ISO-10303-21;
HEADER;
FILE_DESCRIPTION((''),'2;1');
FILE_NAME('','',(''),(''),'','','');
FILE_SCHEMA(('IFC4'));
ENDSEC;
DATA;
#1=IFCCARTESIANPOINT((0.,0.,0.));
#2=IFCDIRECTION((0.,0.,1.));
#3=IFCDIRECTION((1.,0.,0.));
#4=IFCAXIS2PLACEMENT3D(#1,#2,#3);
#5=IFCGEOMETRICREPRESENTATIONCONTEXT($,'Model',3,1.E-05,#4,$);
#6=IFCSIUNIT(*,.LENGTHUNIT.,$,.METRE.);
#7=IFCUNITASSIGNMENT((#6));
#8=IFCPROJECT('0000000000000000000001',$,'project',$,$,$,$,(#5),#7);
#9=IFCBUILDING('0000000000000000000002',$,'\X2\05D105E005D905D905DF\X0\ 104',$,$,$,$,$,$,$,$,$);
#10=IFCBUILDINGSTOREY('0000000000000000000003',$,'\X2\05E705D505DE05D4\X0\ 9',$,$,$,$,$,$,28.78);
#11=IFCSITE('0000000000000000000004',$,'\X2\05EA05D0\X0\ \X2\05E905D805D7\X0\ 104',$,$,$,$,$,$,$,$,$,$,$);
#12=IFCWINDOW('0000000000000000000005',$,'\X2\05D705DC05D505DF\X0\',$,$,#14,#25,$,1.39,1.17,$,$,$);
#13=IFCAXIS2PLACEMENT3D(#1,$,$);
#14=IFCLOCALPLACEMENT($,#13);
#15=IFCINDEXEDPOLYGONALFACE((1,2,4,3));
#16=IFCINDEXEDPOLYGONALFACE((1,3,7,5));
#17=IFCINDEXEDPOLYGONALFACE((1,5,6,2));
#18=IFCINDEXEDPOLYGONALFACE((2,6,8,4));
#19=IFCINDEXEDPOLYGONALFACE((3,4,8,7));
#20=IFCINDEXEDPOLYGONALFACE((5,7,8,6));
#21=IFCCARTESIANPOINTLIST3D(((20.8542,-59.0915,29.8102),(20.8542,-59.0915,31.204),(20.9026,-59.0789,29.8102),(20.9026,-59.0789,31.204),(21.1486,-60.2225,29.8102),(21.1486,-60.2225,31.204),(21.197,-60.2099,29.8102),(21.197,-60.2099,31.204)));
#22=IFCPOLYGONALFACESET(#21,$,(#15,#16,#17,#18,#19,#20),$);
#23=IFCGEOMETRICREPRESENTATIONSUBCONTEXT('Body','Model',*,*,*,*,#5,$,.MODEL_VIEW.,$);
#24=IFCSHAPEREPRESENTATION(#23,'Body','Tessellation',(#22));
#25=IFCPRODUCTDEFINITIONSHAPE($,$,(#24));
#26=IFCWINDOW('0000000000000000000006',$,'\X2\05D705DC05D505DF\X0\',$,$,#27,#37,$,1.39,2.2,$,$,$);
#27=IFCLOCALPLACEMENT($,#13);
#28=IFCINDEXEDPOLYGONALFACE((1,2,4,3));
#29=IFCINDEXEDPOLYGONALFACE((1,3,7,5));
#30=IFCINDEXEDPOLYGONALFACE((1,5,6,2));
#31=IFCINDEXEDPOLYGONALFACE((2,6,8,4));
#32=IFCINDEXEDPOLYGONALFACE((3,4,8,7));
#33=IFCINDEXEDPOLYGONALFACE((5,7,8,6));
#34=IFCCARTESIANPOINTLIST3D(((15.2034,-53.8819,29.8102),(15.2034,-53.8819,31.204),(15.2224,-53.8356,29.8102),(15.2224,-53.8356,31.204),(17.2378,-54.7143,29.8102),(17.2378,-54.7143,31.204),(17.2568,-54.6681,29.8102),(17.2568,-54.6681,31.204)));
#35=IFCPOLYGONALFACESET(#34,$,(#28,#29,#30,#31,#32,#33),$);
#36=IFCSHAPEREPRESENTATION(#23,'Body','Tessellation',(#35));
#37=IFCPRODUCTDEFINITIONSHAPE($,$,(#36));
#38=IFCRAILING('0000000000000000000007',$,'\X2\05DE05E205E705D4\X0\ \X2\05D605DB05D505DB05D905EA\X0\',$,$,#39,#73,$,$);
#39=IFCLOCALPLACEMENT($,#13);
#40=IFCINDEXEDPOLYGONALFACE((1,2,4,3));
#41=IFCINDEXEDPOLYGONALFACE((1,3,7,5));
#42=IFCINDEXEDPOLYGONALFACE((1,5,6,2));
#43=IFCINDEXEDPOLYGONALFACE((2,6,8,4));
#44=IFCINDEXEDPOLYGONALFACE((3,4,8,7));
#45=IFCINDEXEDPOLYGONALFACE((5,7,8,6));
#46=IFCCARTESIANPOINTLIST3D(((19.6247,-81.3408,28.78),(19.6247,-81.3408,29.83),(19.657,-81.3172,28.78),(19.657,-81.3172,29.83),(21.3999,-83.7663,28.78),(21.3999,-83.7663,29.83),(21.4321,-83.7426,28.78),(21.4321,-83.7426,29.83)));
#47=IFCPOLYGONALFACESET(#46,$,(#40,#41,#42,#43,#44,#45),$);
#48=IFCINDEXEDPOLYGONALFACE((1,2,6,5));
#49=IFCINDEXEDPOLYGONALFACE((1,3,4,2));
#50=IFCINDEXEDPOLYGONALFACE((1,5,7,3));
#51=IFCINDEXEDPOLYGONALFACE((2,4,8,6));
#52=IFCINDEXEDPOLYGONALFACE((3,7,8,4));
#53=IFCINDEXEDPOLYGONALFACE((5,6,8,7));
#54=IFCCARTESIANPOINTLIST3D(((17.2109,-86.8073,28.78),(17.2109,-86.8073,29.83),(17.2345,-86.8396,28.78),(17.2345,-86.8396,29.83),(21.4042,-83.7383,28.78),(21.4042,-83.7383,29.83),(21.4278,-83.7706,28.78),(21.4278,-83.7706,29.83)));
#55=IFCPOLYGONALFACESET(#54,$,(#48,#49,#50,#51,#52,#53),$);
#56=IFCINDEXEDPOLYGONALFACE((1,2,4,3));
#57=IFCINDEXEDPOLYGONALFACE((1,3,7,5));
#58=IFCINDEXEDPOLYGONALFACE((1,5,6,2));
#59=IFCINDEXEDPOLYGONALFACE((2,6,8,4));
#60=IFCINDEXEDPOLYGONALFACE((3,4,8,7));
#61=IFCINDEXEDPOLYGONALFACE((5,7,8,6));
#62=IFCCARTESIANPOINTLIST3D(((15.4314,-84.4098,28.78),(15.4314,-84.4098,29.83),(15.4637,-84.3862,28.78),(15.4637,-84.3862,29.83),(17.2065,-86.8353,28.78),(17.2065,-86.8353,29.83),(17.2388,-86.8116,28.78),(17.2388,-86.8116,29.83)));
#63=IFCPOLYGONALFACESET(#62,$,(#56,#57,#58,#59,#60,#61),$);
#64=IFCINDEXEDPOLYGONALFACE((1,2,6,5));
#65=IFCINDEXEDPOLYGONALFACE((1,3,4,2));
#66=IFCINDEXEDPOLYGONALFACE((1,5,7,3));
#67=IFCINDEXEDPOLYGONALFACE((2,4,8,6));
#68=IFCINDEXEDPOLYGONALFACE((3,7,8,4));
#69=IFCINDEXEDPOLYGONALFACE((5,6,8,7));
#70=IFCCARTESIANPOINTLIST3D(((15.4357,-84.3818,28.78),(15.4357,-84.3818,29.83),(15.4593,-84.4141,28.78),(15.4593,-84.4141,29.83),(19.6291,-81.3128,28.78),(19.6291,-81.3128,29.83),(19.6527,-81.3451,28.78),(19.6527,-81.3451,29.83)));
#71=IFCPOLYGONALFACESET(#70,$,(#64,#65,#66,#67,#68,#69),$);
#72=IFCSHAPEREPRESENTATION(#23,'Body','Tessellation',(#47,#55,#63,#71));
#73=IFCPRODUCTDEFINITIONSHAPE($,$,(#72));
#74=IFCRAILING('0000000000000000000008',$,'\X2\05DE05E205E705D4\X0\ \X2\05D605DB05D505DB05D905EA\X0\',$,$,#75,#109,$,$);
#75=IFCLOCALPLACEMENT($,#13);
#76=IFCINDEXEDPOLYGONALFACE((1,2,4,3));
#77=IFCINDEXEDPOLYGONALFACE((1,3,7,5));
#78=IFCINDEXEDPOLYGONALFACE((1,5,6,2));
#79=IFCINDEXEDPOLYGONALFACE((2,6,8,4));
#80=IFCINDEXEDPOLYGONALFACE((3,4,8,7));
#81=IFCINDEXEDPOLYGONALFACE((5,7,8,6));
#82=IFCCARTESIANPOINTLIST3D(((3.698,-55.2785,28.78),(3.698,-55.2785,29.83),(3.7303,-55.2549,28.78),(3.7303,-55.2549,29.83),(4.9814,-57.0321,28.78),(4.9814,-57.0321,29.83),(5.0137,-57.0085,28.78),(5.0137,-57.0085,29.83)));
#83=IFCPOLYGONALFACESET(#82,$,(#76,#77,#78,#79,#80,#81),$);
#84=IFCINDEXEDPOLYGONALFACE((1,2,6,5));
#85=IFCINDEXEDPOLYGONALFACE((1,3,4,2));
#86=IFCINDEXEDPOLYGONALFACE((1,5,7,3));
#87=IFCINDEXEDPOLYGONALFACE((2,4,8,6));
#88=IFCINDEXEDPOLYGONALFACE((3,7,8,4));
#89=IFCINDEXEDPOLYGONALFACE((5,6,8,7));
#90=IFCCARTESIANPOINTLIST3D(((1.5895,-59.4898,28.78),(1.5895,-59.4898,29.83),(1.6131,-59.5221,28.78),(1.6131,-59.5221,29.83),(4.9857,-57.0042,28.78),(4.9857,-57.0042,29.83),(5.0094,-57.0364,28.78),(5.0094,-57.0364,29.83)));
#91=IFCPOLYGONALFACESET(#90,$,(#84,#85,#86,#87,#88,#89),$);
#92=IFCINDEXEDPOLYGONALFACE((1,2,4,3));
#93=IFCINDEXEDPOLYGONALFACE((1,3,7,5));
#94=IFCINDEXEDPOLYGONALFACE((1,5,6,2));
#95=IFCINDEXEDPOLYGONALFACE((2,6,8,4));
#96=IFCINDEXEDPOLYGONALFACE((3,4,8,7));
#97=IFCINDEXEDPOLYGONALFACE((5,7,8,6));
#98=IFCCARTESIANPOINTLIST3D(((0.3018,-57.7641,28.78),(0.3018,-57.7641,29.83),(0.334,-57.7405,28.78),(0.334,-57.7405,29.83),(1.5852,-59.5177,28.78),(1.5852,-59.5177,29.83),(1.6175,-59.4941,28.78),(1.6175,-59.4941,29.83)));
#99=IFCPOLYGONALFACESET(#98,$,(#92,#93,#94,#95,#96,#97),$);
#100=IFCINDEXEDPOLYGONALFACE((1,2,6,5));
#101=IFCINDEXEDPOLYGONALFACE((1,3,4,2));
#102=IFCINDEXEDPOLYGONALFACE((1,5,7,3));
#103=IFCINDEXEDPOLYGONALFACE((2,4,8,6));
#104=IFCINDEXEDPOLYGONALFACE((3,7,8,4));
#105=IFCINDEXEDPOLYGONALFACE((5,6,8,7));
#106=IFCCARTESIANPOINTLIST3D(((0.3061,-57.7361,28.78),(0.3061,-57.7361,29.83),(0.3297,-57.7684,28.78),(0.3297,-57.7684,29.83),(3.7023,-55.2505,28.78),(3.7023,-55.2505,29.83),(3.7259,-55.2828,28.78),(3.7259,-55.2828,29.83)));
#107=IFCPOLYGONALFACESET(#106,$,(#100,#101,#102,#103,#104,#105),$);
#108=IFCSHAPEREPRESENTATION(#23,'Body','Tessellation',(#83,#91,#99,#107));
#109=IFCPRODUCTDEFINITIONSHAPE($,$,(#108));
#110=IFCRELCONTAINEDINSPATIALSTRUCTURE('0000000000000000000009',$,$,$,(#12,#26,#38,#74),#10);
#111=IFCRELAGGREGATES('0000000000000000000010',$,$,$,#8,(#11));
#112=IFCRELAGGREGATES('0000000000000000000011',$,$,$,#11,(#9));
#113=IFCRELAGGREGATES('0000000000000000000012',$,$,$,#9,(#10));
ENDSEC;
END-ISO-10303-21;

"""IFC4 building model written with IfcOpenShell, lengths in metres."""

from ifc_helpers import new_model, si_unit, frame, origin_with_axes, context, subcontext, project, spatial, polyline, outline, extrude, element, save


model = new_model("IFC4")

# Units and contexts
model_context = context("Model", 3, precision=1e-05, world=origin_with_axes())
body_context = subcontext(model_context, "Body", "Model", "MODEL_VIEW")
ifc_project = project(units=[si_unit("LENGTHUNIT", "METRE")], contexts=[model_context])

# Site, building, storey
site = spatial("IfcSite", under=ifc_project, Name="תא שטח 104")
building = spatial("IfcBuilding", under=site, Name="בניין 104")
storey = spatial("IfcBuildingStorey", under=building, Name="קומה 9", Elevation=28.78)

# Windows
element("IfcWindow", 1, inside=storey, Name="חלון", OverallHeight=1.39, OverallWidth=1.17, context=body_context, shape_type="SweptSolid", body=[
    extrude(outline(polyline([(21.197, -60.2099), (20.9026, -59.0789), (20.8542, -59.0915), (21.1486, -60.2225), (21.197, -60.2099)])), frame((0.0, 0.0, 29.8102)), (0.0, 0.0, 1.0), 1.3938),
])
element("IfcWindow", 2, inside=storey, Name="חלון", OverallHeight=1.39, OverallWidth=2.2, context=body_context, shape_type="SweptSolid", body=[
    extrude(outline(polyline([(17.2568, -54.6681), (15.2224, -53.8356), (15.2034, -53.8819), (17.2378, -54.7143), (17.2568, -54.6681)])), frame((0.0, 0.0, 29.8102)), (0.0, 0.0, 1.0), 1.3938),
])

# Railings
element("IfcRailing", 3, inside=storey, Name="מעקה זכוכית", context=body_context, shape_type="SweptSolid", body=[
    extrude(outline(polyline([(19.6247, -81.3408), (21.3999, -83.7663), (21.4321, -83.7426), (19.657, -81.3172), (19.6247, -81.3408)])), frame((0.0, 0.0, 28.78)), (0.0, 0.0, 1.0), 1.05),
    extrude(outline(polyline([(21.4042, -83.7383), (17.2109, -86.8073), (17.2345, -86.8396), (21.4278, -83.7706), (21.4042, -83.7383)])), frame((0.0, 0.0, 28.78)), (0.0, 0.0, 1.0), 1.05),
    extrude(outline(polyline([(17.2388, -86.8116), (15.4637, -84.3862), (15.4314, -84.4098), (17.2065, -86.8353), (17.2388, -86.8116)])), frame((0.0, 0.0, 28.78)), (0.0, 0.0, 1.0), 1.05),
    extrude(outline(polyline([(15.4593, -84.4141), (19.6527, -81.3451), (19.6291, -81.3128), (15.4357, -84.3818), (15.4593, -84.4141)])), frame((0.0, 0.0, 28.78)), (0.0, 0.0, 1.0), 1.05),
])
element("IfcRailing", 4, inside=storey, Name="מעקה זכוכית", context=body_context, shape_type="SweptSolid", body=[
    extrude(outline(polyline([(3.698, -55.2785), (4.9814, -57.0321), (5.0137, -57.0085), (3.7303, -55.2549), (3.698, -55.2785)])), frame((0.0, 0.0, 28.78)), (0.0, 0.0, 1.0), 1.05),
    extrude(outline(polyline([(4.9857, -57.0042), (1.5895, -59.4898), (1.6131, -59.5221), (5.0094, -57.0364), (4.9857, -57.0042)])), frame((0.0, 0.0, 28.78)), (0.0, 0.0, 1.0), 1.05),
    extrude(outline(polyline([(1.6175, -59.4941), (0.334, -57.7405), (0.3018, -57.7641), (1.5852, -59.5177), (1.6175, -59.4941)])), frame((0.0, 0.0, 28.78)), (0.0, 0.0, 1.0), 1.05),
    extrude(outline(polyline([(0.3297, -57.7684), (3.7259, -55.2828), (3.7023, -55.2505), (0.3061, -57.7361), (0.3297, -57.7684)])), frame((0.0, 0.0, 28.78)), (0.0, 0.0, 1.0), 1.05),
])

save(model, "model.ifc")
